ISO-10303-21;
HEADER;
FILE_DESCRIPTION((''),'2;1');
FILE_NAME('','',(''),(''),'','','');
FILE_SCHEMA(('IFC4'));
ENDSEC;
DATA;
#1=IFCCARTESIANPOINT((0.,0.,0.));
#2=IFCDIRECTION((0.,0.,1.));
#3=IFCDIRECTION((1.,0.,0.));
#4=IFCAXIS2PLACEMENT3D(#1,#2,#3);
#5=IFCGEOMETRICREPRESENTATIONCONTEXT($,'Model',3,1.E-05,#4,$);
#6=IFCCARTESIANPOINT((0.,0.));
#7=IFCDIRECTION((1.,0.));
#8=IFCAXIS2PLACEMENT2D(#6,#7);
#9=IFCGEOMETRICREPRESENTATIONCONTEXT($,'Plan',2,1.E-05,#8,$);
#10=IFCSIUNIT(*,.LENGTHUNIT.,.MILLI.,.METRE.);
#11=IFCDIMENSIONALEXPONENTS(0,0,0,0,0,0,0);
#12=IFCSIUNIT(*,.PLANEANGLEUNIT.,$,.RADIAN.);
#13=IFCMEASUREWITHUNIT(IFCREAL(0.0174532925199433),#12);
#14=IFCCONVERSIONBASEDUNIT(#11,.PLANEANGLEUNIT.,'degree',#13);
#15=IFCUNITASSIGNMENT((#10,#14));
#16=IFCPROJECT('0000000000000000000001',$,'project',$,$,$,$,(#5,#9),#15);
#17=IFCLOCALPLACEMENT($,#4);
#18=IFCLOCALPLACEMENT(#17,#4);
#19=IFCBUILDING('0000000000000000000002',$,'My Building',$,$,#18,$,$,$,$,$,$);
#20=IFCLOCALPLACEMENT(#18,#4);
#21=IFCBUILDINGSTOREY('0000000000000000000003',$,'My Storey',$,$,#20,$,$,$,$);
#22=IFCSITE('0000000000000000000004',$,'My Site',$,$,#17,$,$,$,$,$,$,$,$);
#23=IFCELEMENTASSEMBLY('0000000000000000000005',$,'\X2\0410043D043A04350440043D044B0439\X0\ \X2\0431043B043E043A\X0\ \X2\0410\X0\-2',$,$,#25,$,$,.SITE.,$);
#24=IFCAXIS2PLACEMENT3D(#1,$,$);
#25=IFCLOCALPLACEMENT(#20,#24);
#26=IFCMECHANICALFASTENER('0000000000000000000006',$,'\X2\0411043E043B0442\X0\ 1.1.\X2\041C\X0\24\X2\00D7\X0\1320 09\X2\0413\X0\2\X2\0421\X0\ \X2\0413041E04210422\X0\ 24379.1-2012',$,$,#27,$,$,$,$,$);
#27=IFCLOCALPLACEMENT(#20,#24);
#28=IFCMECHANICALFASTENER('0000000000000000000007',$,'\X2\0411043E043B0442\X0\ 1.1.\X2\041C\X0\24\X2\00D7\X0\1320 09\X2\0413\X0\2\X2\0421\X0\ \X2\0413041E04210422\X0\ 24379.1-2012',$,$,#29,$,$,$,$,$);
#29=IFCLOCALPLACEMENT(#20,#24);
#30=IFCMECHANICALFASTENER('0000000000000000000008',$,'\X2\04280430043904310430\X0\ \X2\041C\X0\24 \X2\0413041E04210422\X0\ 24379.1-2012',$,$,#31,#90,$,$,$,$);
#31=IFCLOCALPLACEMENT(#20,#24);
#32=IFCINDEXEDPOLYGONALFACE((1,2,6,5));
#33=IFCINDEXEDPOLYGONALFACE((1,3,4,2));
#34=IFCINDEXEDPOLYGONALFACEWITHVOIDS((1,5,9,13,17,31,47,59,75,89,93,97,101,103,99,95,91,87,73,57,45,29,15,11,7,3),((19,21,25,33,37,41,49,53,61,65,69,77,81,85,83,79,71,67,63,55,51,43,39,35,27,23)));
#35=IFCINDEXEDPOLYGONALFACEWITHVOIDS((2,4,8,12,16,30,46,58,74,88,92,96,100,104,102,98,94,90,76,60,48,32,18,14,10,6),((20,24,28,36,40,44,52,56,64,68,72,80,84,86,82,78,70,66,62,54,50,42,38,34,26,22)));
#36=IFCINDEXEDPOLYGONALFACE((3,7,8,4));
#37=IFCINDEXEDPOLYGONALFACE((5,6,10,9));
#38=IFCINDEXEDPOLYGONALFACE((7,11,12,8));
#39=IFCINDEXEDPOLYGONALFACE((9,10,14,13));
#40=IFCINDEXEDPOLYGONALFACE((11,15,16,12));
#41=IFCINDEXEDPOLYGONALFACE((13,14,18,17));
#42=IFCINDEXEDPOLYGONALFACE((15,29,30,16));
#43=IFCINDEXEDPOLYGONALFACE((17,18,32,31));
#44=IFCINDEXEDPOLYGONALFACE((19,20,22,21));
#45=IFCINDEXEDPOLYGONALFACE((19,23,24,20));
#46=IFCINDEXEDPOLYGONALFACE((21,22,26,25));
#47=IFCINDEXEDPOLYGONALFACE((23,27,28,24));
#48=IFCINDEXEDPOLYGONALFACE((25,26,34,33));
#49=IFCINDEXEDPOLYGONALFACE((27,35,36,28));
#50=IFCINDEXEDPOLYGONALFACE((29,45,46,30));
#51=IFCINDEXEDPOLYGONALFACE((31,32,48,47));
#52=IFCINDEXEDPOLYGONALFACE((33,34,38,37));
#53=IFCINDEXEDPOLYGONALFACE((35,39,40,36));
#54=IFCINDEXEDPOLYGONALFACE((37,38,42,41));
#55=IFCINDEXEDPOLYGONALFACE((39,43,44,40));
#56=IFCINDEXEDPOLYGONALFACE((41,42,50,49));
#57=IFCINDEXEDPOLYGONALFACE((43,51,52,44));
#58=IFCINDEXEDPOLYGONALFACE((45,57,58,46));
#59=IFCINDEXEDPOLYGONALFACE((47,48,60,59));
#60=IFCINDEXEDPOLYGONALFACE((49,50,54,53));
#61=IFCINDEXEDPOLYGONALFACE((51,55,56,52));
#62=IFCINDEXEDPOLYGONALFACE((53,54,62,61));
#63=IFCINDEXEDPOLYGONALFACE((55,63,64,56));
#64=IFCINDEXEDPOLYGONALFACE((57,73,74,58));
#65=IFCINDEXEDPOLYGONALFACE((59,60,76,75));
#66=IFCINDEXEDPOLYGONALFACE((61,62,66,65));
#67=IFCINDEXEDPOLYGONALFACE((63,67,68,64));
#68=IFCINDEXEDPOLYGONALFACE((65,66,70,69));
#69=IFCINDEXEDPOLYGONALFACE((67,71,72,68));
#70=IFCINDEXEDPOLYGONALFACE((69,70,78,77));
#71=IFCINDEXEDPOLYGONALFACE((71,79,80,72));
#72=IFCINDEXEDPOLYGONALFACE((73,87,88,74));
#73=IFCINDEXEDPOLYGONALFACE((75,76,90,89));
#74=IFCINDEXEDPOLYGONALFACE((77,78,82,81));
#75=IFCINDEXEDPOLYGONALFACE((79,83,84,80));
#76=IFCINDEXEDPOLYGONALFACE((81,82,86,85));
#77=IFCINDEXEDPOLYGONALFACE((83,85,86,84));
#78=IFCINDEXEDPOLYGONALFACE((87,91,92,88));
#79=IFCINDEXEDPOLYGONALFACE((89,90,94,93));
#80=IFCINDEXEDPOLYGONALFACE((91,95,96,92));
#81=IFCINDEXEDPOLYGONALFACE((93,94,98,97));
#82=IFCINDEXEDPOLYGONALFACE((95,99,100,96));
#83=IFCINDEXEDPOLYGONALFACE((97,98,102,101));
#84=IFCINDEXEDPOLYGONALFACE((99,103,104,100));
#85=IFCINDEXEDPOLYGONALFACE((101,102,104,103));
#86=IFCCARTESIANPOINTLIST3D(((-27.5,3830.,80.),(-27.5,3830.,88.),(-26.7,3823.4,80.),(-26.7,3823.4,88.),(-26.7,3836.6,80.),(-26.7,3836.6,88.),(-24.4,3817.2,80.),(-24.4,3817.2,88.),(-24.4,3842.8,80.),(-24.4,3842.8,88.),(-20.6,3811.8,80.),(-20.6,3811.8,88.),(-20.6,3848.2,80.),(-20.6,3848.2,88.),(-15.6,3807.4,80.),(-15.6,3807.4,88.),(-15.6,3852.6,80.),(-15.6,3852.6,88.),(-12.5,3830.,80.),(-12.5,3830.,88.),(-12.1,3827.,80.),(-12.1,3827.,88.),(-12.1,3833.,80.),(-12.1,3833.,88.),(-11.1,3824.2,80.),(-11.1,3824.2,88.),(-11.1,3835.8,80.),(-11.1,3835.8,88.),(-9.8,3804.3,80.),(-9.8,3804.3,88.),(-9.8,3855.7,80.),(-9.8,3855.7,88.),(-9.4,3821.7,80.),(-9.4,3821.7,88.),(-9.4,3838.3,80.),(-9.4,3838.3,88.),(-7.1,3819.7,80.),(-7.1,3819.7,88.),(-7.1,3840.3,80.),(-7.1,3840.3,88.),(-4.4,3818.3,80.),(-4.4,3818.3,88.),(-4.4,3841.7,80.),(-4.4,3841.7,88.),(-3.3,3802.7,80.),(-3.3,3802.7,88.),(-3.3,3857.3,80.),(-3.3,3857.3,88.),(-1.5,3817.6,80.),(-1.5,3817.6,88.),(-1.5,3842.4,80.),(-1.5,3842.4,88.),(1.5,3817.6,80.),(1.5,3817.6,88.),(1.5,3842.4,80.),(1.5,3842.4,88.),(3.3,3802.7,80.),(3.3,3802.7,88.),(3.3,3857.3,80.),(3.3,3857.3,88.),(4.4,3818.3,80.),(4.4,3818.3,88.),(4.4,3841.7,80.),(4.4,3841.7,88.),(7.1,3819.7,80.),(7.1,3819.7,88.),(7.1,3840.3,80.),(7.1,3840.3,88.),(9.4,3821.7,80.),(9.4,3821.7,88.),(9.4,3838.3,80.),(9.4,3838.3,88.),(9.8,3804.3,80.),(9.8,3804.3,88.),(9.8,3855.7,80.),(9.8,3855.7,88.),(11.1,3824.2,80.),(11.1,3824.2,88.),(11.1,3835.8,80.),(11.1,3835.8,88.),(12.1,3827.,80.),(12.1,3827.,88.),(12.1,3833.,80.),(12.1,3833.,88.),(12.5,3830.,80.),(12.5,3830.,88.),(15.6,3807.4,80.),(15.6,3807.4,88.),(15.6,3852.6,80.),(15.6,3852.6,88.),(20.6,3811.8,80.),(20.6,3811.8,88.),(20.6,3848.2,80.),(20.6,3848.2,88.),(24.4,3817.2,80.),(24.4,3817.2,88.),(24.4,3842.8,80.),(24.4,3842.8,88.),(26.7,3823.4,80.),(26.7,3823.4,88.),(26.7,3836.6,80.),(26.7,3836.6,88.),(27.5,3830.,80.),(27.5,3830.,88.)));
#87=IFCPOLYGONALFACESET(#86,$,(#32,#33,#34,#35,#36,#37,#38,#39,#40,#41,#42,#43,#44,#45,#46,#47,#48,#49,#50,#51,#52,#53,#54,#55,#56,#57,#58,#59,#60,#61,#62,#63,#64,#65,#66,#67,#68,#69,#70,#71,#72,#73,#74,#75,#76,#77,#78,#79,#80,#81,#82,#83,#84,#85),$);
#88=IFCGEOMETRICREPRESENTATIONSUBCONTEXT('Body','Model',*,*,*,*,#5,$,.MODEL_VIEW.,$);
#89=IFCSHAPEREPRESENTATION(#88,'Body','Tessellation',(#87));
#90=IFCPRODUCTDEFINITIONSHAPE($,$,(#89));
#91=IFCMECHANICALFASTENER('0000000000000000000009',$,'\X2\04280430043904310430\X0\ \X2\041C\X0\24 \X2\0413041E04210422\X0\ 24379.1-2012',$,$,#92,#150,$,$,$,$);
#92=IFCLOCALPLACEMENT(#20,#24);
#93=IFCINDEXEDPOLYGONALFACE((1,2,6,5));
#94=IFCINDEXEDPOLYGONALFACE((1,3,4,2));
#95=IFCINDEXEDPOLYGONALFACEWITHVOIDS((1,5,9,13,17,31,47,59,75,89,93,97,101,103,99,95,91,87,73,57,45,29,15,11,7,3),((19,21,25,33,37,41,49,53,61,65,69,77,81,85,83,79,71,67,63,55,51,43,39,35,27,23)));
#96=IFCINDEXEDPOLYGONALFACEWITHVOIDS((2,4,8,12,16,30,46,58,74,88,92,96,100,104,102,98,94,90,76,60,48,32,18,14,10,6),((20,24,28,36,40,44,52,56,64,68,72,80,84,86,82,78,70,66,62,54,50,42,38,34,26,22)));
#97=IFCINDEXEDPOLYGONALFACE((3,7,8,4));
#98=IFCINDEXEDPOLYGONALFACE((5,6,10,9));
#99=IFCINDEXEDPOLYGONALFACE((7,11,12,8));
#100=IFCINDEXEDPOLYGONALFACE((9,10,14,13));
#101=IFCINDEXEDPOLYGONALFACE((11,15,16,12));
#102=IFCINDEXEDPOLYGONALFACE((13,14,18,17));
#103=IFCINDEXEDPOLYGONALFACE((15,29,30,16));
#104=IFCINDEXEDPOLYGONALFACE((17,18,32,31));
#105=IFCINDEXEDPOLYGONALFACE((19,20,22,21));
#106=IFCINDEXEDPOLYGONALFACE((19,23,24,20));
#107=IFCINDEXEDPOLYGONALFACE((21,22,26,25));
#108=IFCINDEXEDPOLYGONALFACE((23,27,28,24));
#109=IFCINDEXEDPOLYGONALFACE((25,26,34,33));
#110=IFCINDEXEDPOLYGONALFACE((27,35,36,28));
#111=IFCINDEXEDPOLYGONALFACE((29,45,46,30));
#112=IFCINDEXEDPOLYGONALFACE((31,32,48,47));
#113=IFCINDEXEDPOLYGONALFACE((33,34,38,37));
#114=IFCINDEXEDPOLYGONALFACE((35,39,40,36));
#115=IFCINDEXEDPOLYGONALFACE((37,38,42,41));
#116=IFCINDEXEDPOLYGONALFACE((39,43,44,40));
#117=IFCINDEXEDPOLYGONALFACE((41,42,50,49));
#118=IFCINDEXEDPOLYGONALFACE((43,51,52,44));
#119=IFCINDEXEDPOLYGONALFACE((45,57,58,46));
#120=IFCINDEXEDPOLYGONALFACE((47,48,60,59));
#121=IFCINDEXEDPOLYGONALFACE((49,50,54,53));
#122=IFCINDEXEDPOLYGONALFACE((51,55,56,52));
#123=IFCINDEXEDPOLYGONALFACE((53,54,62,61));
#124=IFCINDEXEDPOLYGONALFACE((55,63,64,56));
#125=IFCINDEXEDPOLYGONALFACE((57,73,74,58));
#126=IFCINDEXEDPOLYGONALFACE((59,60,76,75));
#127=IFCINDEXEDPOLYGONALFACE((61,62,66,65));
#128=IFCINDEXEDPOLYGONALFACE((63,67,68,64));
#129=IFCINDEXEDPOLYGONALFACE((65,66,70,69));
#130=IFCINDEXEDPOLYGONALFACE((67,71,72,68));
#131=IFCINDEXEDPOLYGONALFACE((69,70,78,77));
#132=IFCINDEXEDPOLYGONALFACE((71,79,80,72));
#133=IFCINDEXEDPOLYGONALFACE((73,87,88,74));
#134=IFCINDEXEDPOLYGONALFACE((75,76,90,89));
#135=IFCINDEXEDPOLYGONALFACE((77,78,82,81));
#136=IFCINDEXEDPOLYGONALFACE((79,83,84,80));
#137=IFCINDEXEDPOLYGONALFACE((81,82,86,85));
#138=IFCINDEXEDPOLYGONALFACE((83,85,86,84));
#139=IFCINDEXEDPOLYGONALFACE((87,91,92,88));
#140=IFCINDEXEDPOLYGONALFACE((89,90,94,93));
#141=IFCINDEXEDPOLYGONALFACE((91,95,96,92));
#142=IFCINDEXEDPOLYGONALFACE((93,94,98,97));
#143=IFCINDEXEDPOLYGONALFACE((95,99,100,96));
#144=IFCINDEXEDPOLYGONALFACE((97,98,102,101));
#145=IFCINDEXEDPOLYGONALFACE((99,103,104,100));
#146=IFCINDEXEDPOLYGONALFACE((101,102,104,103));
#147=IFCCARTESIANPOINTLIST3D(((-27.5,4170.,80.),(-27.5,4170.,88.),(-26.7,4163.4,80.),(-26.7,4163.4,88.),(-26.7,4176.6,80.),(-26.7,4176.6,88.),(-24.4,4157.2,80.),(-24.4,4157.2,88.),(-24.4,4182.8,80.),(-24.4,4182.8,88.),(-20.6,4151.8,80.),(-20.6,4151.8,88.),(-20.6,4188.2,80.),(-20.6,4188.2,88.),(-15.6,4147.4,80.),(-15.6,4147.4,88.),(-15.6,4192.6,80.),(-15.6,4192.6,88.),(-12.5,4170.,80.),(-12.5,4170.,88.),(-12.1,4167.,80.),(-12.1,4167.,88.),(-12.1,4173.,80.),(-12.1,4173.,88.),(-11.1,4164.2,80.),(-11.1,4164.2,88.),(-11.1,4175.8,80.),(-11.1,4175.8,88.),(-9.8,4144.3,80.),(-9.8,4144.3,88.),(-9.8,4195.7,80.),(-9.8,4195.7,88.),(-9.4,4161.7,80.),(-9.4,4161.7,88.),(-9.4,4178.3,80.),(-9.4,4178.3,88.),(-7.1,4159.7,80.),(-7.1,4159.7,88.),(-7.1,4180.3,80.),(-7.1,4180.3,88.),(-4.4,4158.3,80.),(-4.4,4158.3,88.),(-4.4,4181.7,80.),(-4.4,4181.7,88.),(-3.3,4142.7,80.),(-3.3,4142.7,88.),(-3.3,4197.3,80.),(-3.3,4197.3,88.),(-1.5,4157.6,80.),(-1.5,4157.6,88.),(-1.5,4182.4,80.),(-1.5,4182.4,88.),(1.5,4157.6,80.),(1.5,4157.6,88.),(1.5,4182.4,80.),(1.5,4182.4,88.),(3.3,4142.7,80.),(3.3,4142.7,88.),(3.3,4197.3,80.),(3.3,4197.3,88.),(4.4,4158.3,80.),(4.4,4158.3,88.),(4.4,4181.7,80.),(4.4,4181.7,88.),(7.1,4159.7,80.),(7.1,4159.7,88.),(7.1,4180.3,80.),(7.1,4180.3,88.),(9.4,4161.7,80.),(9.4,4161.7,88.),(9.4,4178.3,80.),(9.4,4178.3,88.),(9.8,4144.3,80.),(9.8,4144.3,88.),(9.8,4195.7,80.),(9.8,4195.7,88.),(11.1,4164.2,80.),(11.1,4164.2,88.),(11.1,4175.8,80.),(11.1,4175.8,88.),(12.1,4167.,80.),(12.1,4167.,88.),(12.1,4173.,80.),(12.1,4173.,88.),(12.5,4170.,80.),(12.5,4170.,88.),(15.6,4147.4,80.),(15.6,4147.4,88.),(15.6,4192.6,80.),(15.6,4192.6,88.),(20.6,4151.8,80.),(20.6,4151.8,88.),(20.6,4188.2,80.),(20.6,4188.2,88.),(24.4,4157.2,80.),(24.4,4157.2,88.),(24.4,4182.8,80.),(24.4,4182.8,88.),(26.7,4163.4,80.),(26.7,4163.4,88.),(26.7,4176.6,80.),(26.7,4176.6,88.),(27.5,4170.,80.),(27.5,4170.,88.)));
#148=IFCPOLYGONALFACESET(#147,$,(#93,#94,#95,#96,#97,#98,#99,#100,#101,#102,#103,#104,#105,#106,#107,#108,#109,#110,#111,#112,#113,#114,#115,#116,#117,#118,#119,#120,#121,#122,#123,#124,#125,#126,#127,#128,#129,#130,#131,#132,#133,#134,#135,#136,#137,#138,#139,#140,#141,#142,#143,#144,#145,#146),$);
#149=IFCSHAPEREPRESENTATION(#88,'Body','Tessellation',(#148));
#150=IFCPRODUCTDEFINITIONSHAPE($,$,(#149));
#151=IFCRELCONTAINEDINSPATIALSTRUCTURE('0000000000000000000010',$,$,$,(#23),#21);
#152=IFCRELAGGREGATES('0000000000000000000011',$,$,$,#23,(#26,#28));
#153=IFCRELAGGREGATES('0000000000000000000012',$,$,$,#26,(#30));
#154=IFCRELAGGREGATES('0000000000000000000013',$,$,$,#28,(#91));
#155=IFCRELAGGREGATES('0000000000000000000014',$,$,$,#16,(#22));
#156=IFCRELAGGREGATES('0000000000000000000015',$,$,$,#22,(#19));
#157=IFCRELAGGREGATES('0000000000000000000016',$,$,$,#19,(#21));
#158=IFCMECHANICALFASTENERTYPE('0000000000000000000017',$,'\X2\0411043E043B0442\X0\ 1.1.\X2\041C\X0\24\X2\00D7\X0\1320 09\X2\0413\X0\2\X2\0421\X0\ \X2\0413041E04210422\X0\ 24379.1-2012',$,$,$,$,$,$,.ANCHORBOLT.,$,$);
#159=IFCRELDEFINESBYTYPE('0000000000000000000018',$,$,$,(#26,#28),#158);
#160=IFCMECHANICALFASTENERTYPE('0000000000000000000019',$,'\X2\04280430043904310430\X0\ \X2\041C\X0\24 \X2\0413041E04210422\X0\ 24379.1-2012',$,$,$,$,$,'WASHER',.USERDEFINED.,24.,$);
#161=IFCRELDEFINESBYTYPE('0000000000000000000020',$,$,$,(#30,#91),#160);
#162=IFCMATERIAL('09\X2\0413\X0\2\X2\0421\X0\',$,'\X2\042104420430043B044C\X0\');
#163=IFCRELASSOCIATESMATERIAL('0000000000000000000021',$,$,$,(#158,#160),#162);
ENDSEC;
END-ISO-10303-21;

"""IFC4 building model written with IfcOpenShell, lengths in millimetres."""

from ifc_helpers import new_model, entity, si_unit, converted_unit, frame, origin_with_axes, origin_2d_with_axis, place, context, subcontext, project, spatial, polyline, outline, extrude, source, transform, mapped, material, type_object, type_shapes, element, aggregate, save


model = new_model("IFC4")

# Units and contexts
model_context = context("Model", 3, precision=1e-05, world=origin_with_axes())
plan_context = context("Plan", 2, precision=1e-05, world=origin_2d_with_axis())
body_context = subcontext(model_context, "Body", "Model", "MODEL_VIEW")
ifc_project = project(units=[si_unit("LENGTHUNIT", "METRE", prefix="MILLI"), converted_unit("PLANEANGLEUNIT", "degree", entity("IfcReal", 0.0174532925199433), si_unit("PLANEANGLEUNIT", "RADIAN"), dimensions=[0, 0, 0, 0, 0, 0, 0])], contexts=[model_context, plan_context])

# Site, building, storey
site_placement = place(None, origin_with_axes())
site = spatial("IfcSite", under=ifc_project, at=site_placement, Name="My Site")
building_placement = place(site_placement, origin_with_axes())
building = spatial("IfcBuilding", under=site, at=building_placement, Name="My Building")
storey_placement = place(building_placement, origin_with_axes())
storey = spatial("IfcBuildingStorey", under=building, at=storey_placement, Name="My Storey")

# Shared definitions
placement = place(storey_placement, frame((0.0, 4000.0, 0.0), z_axis=(0.0, 0.0, 1.0), x_axis=(1.0, 0.0, 0.0)))

# Element assembly, mechanical fasteners
assembly_1 = element("IfcElementAssembly", 1, at=placement, inside=storey, Name="Анкерный блок А-2", AssemblyPlace="SITE")
ifc_material_1 = material(Name="09Г2С", Category="Сталь")
mechanical_fastener_type_1 = type_object("IfcMechanicalFastenerType", Name="Болт 1.1.М24×1320 09Г2С ГОСТ 24379.1-2012", PredefinedType="ANCHORBOLT", material=ifc_material_1)
mechanical_fastener_1_placement = place(placement, frame((0.0, -170.0, 0.0), z_axis=(0.0, 0.0, 1.0), x_axis=(1.0, 0.0, 0.0)))
mechanical_fastener_1 = element("IfcMechanicalFastener", 2, at=mechanical_fastener_1_placement, type_object=mechanical_fastener_type_1, Name="Болт 1.1.М24×1320 09Г2С ГОСТ 24379.1-2012")
mechanical_fastener_2_placement = place(placement, frame((0.0, 170.0, 0.0), z_axis=(0.0, 0.0, 1.0), x_axis=(-1.0, 0.0, 0.0)))
mechanical_fastener_2 = element("IfcMechanicalFastener", 3, at=mechanical_fastener_2_placement, type_object=mechanical_fastener_type_1, Name="Болт 1.1.М24×1320 09Г2С ГОСТ 24379.1-2012")
aggregate(assembly_1, [mechanical_fastener_1, mechanical_fastener_2])

# Mechanical fasteners
mechanical_fastener_type_2 = type_object("IfcMechanicalFastenerType", Name="Шайба М24 ГОСТ 24379.1-2012", ElementType="WASHER", NominalDiameter=24.0, PredefinedType="USERDEFINED", material=ifc_material_1)
shared_shape_1 = source(origin_with_axes(), body_context, "Body", "SweptSolid", [
    extrude(outline(polyline([(27.5, 0.0), (26.7, 6.6), (24.4, 12.8), (20.6, 18.2), (15.6, 22.6), (9.8, 25.7), (3.3, 27.3), (-3.3, 27.3), (-9.8, 25.7), (-15.6, 22.6), (-20.6, 18.2), (-24.4, 12.8), (-26.7, 6.6), (-27.5, 0.0), (-26.7, -6.6), (-24.4, -12.8), (-20.6, -18.2), (-15.6, -22.6), (-9.8, -25.7), (-3.3, -27.3), (3.3, -27.3), (9.8, -25.7), (15.6, -22.6), (20.6, -18.2), (24.4, -12.8), (26.7, -6.6), (27.5, 0.0)]), holes=[polyline([(-4.4, -11.7), (-7.1, -10.3), (-9.4, -8.3), (-11.1, -5.8), (-12.1, -3.0), (-12.5, 0.0), (-12.1, 3.0), (-11.1, 5.8), (-9.4, 8.3), (-7.1, 10.3), (-4.4, 11.7), (-1.5, 12.4), (1.5, 12.4), (4.4, 11.7), (7.1, 10.3), (9.4, 8.3), (11.1, 5.8), (12.1, 3.0), (12.5, 0.0), (12.1, -3.0), (11.1, -5.8), (9.4, -8.3), (7.1, -10.3), (4.4, -11.7), (1.5, -12.4), (-1.5, -12.4), (-4.4, -11.7)])]), frame((0.0, 0.0, 0.0), z_axis=(0.0, 0.0, 1.0), x_axis=(0.120537, -0.992709, 0.0)), (0.0, 0.0, 1.0), 8.0),
])
type_shapes(mechanical_fastener_type_2, [shared_shape_1])
mechanical_fastener_3_placement = place(mechanical_fastener_1_placement, frame((0.0, 0.0, 80.0), z_axis=(0.0, 0.0, 1.0), x_axis=(1.0, 0.0, 0.0)))
mechanical_fastener_3 = element("IfcMechanicalFastener", 4, at=mechanical_fastener_3_placement, type_object=mechanical_fastener_type_2, Name="Шайба М24 ГОСТ 24379.1-2012", context=body_context, shape_type="MappedRepresentation", body=[
    mapped(shared_shape_1, transform((0.0, 0.0, 0.0), x_axis=(1.0, 0.0, 0.0), y_axis=(0.0, 1.0, 0.0), z_axis=(0.0, 0.0, 1.0), scale=1.0)),
])
aggregate(mechanical_fastener_1, [mechanical_fastener_3])
mechanical_fastener_4_placement = place(mechanical_fastener_2_placement, frame((0.0, 0.0, 80.0), z_axis=(0.0, 0.0, 1.0), x_axis=(1.0, 0.0, 0.0)))
mechanical_fastener_4 = element("IfcMechanicalFastener", 5, at=mechanical_fastener_4_placement, type_object=mechanical_fastener_type_2, Name="Шайба М24 ГОСТ 24379.1-2012", context=body_context, shape_type="MappedRepresentation", body=[
    mapped(shared_shape_1, transform((0.0, 0.0, 0.0), x_axis=(1.0, 0.0, 0.0), y_axis=(0.0, 1.0, 0.0), z_axis=(0.0, 0.0, 1.0), scale=1.0)),
])
aggregate(mechanical_fastener_2, [mechanical_fastener_4])

save(model, "model.ifc")
